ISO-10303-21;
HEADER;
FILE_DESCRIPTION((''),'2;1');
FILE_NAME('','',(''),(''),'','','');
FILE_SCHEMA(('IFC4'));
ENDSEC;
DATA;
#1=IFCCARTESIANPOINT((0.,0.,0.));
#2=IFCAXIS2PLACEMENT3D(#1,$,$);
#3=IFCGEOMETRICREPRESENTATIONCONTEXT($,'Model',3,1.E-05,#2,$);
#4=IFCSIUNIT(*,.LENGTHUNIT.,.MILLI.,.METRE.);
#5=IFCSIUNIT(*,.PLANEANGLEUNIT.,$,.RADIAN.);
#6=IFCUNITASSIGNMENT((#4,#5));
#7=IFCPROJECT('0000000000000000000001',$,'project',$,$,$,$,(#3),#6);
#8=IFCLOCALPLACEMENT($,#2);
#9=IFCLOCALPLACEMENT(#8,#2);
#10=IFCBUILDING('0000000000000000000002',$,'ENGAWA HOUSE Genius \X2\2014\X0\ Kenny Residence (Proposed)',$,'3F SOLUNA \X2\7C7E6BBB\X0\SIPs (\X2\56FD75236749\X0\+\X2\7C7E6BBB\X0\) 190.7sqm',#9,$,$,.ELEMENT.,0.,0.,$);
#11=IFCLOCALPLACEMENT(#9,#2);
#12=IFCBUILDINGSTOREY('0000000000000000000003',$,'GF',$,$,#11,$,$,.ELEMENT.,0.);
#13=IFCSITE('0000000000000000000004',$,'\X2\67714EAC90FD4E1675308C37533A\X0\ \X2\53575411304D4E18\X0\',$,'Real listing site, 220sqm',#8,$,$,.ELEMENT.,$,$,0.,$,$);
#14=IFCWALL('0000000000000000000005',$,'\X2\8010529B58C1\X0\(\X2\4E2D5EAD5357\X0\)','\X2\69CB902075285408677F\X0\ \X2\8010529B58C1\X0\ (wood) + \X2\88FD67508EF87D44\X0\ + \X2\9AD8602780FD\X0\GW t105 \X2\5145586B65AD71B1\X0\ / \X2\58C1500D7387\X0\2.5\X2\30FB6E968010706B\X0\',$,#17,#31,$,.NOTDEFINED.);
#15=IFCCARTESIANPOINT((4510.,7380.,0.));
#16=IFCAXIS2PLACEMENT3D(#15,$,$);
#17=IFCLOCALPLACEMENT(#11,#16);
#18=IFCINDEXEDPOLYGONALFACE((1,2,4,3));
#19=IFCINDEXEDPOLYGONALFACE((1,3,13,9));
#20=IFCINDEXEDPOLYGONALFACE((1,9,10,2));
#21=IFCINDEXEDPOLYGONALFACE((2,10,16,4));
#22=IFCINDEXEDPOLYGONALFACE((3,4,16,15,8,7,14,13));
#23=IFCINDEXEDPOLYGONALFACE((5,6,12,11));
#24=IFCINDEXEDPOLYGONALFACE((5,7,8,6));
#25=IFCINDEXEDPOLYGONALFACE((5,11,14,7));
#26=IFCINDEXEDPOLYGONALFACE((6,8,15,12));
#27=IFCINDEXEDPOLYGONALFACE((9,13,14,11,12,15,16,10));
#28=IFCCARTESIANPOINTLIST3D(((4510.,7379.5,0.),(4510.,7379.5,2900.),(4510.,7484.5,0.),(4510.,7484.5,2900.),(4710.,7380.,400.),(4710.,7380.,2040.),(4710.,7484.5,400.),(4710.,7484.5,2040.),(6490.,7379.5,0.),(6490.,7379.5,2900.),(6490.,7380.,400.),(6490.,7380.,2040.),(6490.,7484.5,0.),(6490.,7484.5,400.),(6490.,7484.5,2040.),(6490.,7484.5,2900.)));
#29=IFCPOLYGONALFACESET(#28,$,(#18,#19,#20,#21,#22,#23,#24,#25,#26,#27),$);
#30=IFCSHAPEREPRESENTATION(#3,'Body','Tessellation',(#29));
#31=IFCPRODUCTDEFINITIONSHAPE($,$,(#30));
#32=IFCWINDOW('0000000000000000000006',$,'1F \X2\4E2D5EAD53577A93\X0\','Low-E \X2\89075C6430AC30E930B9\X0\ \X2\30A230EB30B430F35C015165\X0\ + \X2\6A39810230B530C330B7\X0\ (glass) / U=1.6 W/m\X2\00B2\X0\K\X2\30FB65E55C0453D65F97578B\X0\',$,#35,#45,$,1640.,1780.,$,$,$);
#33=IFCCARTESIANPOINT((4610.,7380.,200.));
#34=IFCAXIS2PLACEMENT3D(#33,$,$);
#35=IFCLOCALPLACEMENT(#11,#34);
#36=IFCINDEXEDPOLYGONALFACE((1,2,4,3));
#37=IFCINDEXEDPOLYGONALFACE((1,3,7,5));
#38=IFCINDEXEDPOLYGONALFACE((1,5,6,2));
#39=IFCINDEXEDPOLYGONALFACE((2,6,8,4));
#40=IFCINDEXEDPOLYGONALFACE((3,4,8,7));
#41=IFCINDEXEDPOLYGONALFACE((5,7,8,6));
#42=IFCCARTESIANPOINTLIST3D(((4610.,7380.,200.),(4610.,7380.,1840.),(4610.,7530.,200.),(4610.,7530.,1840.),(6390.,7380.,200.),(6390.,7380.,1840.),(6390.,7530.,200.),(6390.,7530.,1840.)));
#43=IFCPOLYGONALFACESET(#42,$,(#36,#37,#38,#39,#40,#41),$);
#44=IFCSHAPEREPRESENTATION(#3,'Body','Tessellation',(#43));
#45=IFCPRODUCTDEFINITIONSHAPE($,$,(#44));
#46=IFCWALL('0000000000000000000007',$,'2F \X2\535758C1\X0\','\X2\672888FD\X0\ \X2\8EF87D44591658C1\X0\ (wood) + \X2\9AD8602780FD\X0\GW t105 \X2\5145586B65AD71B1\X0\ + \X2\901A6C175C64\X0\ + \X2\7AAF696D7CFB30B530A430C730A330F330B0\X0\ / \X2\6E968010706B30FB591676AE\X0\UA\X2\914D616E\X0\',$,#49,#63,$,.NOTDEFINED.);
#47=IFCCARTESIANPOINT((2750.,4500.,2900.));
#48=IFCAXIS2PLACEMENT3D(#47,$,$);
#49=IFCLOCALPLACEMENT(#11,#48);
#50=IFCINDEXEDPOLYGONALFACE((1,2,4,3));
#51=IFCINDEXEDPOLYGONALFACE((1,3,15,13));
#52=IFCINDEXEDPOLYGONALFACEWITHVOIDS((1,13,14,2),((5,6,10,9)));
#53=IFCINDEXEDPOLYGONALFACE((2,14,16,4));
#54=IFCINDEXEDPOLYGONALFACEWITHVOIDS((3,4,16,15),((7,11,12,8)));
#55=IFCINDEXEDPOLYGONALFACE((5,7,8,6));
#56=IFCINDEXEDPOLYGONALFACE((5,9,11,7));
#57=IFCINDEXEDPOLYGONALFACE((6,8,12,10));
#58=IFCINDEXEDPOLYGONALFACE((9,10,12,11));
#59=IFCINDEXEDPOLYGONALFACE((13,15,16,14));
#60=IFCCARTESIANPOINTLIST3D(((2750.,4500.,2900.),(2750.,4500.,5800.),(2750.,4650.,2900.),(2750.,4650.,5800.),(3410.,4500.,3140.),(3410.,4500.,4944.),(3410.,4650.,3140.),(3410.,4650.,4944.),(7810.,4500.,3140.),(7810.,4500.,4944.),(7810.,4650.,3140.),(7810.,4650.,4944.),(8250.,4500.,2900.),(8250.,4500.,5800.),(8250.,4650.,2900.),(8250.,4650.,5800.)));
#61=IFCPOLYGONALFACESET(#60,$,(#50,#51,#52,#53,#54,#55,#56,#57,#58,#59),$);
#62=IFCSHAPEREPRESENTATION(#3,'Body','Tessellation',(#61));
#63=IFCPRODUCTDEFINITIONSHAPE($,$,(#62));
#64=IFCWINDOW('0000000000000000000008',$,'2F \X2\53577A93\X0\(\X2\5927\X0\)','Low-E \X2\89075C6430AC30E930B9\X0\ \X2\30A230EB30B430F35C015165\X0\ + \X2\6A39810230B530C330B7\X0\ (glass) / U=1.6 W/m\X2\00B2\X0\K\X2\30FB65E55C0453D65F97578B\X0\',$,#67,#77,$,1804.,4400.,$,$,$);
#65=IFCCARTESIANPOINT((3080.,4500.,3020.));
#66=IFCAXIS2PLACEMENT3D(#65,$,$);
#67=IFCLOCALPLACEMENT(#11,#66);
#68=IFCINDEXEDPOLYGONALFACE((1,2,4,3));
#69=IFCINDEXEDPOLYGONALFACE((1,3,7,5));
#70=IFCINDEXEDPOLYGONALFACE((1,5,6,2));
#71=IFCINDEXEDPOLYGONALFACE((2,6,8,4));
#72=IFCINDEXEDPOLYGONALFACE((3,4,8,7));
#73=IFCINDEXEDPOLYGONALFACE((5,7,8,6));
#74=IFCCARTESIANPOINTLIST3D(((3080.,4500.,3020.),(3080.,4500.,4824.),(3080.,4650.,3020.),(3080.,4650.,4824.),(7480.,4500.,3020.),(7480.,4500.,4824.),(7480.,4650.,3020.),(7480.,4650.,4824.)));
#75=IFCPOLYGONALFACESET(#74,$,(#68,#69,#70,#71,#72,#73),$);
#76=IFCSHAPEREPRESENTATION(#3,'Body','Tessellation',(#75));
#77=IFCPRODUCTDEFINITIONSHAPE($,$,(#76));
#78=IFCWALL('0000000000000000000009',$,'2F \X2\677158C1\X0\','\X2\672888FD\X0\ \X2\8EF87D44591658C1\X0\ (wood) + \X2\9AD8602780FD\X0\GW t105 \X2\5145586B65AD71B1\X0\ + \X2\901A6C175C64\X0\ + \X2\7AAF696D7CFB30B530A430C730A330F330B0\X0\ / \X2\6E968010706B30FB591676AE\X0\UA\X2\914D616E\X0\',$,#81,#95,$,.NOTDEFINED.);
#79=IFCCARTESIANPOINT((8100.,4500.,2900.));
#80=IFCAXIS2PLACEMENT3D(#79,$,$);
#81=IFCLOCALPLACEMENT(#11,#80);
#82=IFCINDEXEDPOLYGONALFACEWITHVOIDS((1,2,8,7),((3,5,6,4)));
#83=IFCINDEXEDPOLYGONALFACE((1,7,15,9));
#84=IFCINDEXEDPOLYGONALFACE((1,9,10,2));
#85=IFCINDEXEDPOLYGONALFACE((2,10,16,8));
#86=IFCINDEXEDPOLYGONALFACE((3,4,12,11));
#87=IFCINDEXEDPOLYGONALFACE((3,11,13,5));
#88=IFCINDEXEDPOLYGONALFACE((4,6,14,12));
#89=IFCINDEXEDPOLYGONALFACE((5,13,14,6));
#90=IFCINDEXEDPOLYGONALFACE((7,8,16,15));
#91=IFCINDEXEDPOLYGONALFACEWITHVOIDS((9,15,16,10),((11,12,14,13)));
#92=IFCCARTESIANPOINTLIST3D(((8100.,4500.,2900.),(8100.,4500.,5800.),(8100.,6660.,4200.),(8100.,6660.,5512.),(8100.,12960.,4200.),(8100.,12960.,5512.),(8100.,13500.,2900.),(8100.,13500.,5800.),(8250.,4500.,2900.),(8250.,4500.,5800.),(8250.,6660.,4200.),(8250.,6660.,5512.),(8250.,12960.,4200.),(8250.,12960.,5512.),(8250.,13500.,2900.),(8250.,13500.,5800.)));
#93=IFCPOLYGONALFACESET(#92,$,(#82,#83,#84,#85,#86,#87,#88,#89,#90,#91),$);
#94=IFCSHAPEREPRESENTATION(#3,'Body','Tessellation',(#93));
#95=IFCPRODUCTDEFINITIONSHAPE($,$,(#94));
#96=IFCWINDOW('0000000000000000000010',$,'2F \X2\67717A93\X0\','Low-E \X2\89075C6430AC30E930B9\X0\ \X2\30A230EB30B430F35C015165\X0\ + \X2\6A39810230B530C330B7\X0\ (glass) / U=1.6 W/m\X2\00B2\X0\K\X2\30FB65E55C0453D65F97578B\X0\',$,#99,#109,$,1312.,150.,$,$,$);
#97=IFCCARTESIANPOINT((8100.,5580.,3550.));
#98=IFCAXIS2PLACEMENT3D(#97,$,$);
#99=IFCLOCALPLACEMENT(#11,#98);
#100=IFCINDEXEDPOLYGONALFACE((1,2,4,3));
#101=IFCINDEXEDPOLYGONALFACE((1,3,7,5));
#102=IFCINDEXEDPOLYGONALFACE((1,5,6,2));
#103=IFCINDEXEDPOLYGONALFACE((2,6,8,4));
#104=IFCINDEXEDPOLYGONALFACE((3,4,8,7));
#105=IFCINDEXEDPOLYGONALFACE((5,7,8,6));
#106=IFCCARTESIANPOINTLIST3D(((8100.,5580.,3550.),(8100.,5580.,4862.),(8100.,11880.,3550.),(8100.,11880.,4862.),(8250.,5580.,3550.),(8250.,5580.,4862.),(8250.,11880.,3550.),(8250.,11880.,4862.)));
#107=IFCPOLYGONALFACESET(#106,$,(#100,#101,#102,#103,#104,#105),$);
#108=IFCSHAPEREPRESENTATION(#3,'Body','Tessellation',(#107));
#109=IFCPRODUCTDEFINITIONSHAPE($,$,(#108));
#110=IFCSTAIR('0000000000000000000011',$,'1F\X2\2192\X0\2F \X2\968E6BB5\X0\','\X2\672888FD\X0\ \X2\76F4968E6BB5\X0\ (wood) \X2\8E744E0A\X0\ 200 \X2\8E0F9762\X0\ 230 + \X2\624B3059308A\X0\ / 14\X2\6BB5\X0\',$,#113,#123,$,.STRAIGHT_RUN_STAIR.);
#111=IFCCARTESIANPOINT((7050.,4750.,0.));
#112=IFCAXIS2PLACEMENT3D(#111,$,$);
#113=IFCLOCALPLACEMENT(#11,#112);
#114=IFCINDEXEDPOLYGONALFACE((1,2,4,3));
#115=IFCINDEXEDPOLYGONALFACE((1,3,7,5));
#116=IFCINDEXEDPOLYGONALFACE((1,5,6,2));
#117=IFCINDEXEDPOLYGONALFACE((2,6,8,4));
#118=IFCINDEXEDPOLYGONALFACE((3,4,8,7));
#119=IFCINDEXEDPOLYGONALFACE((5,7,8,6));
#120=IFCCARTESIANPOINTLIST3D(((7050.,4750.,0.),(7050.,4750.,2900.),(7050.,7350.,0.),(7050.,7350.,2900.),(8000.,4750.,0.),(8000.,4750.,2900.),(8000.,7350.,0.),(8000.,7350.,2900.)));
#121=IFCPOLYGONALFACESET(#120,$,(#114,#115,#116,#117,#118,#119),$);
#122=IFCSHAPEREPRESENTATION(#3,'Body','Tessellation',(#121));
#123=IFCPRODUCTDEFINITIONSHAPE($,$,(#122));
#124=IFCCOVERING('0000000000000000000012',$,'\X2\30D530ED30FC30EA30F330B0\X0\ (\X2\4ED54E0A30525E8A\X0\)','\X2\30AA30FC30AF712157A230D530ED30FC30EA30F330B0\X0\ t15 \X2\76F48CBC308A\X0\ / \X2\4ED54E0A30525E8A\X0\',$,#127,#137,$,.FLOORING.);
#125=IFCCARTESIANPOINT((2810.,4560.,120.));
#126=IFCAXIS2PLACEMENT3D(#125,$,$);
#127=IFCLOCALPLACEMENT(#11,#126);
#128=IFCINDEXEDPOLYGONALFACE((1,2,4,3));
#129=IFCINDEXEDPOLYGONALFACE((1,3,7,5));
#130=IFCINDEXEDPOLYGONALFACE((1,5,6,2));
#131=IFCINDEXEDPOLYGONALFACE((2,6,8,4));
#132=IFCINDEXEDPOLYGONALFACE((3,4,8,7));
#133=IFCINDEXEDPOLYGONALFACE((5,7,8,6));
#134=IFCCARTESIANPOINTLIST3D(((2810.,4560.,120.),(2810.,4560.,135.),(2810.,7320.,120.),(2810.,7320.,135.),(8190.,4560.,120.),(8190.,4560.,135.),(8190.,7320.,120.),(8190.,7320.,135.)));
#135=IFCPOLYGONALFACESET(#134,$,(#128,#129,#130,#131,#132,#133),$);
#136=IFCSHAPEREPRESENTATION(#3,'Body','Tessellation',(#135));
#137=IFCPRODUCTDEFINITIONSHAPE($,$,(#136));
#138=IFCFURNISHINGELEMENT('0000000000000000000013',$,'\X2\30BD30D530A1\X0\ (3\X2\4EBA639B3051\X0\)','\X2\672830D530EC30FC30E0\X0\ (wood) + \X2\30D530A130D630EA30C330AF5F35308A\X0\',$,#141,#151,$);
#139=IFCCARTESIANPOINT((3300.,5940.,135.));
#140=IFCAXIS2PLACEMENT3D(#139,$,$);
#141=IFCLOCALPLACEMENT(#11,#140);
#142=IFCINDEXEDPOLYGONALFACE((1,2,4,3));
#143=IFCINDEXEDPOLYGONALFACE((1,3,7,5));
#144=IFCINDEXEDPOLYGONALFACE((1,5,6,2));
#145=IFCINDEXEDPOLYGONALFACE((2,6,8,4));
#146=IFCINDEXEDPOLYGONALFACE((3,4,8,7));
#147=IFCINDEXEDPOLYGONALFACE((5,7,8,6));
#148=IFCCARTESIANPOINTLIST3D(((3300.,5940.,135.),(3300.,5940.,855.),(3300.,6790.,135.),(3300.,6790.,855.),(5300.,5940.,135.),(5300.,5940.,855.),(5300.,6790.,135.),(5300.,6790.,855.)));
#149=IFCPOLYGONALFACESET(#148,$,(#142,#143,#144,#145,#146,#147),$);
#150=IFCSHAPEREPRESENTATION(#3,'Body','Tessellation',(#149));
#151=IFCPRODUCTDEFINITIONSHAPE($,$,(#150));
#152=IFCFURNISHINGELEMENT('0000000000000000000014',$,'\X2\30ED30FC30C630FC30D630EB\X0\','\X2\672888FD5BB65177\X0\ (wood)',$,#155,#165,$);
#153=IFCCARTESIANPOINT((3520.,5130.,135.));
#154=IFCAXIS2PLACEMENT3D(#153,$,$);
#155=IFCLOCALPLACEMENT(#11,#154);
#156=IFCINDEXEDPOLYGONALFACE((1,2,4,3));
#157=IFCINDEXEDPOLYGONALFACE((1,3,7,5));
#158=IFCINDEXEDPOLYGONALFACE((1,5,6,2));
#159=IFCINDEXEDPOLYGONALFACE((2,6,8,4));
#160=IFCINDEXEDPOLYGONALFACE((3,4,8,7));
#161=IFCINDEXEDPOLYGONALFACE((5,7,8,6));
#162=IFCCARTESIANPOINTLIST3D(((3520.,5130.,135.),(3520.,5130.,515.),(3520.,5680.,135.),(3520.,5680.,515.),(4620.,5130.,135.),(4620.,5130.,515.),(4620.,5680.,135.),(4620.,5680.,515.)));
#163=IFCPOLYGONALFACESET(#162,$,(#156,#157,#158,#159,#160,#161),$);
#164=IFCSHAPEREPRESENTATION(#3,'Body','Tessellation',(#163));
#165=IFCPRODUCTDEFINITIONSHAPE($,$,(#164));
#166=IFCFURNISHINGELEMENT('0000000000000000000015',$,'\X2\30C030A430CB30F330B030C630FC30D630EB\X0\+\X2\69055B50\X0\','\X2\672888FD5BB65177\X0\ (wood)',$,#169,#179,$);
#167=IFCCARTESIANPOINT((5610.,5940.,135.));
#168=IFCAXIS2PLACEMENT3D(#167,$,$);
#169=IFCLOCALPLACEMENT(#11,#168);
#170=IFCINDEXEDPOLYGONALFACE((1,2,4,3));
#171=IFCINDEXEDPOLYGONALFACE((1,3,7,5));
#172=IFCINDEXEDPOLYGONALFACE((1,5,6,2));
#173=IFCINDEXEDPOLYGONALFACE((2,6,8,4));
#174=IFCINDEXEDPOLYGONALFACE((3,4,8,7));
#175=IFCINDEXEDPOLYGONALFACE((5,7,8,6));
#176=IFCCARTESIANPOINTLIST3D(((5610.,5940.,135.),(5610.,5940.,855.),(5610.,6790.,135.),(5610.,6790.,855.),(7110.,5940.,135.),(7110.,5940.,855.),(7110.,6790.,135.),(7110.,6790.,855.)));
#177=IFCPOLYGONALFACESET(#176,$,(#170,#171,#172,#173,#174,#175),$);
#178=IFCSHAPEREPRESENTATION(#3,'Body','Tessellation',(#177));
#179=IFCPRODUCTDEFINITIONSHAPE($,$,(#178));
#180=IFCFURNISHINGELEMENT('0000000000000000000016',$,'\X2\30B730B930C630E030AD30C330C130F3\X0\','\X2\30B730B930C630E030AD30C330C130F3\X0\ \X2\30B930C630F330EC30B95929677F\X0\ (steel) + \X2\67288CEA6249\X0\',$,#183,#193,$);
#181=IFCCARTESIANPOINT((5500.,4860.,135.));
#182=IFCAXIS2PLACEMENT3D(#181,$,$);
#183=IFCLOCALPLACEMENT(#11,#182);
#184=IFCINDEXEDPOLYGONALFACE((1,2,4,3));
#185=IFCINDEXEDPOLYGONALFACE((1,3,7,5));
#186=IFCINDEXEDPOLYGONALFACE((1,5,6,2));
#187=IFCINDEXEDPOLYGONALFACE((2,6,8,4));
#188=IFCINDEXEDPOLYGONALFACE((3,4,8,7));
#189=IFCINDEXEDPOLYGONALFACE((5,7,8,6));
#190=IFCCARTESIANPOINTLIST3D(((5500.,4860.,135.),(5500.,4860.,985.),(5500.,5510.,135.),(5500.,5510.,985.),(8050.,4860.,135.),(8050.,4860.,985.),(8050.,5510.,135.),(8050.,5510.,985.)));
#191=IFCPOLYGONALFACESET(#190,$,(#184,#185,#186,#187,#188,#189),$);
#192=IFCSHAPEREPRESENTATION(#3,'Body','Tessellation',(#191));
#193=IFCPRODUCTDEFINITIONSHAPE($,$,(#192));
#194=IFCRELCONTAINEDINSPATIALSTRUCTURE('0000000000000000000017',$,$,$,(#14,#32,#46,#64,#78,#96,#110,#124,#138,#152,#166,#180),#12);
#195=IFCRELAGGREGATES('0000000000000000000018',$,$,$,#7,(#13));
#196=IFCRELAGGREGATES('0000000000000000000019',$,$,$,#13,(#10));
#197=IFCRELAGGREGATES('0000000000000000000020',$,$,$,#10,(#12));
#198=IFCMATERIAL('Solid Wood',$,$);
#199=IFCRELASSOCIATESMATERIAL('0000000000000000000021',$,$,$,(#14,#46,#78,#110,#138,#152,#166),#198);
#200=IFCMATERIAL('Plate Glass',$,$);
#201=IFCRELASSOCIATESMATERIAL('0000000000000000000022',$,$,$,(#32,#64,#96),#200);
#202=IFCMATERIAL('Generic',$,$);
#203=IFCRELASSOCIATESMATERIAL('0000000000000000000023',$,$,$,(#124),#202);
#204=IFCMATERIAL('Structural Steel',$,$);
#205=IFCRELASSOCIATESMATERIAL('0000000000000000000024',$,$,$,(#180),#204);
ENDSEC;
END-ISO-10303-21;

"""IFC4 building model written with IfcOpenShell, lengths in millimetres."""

from ifc_helpers import new_model, si_unit, frame, frame_2d, origin, place, context, project, spatial, rectangle, extrude, material, element, fill, save


model = new_model("IFC4")

# Units and contexts
model_context = context("Model", 3, precision=1e-05, world=origin())
ifc_project = project(units=[si_unit("LENGTHUNIT", "METRE", prefix="MILLI"), si_unit("PLANEANGLEUNIT", "RADIAN")], contexts=[model_context])

# Site, building, storey
site_placement = place(None, origin())
site = spatial("IfcSite", under=ifc_project, at=site_placement, Name="東京都世田谷区 南向き丘", ObjectType="Real listing site, 220sqm", CompositionType="ELEMENT", RefElevation=0.0)
building_placement = place(site_placement, origin())
building = spatial("IfcBuilding", under=site, at=building_placement, Name="ENGAWA HOUSE Genius — Kenny Residence (Proposed)", ObjectType="3F SOLUNA 籾殻SIPs (国産杉+籾殻) 190.7sqm", CompositionType="ELEMENT", ElevationOfRefHeight=0.0, ElevationOfTerrain=0.0)
storey_placement = place(building_placement, origin())
storey = spatial("IfcBuildingStorey", under=building, at=storey_placement, Name="GF", CompositionType="ELEMENT", Elevation=0.0)

# Shared definitions
ifc_material_1 = material(Name="Solid Wood")
ifc_material_2 = material(Name="Generic")

# Shared definitions
ifc_material_3 = material(Name="Plate Glass")

# Wall, opening, window
wall_1_placement = place(storey_placement, frame((4510.0, 7380.0, 0.0)))
wall_1 = element("IfcWall", 1, at=wall_1_placement, inside=storey, material=ifc_material_1, Name="耐力壁(中庭南)", Description="構造用合板 耐力壁 (wood) + 製材軸組 + 高性能GW t105 充填断熱 / 壁倍率2.5・準耐火", PredefinedType="NOTDEFINED", context=model_context, shape_type="SweptSolid", body=[
    extrude(rectangle(XDim=1980.0, YDim=105.0, at=frame_2d((990.0, 52.0))), frame((4510.0, 7380.0, 0.0)), (0.0, 0.0, 1.0), 2900.0),
])
opening_1_placement = place(storey_placement, frame((4610.0, 7380.0, 200.0)))
opening_1 = element("IfcOpeningElement", 2, at=opening_1_placement, cuts=wall_1, PredefinedType="NOTDEFINED", context=model_context, shape_type="SweptSolid", body=[
    extrude(rectangle(XDim=1780.0, YDim=150.0, at=frame_2d((890.0, 75.0))), frame((4610.0, 7380.0, 200.0)), (0.0, 0.0, 1.0), 1640.0),
])
window_1_placement = place(storey_placement, frame((4610.0, 7380.0, 200.0)))
window_1 = element("IfcWindow", 3, at=window_1_placement, inside=storey, material=ifc_material_3, Name="1F 中庭南窓", Description="Low-E 複層ガラス アルゴン封入 + 樹脂サッシ (glass) / U=1.6 W/m²K・日射取得型", OverallHeight=1640.0, OverallWidth=1780.0, context=model_context, shape_type="SweptSolid", body=[
    extrude(rectangle(XDim=1780.0, YDim=150.0, at=frame_2d((890.0, 75.0))), frame((4610.0, 7380.0, 200.0)), (0.0, 0.0, 1.0), 1640.0),
])
fill(opening_1, window_1)

# Walls, openings, windows
wall_2_placement = place(storey_placement, frame((2750.0, 4500.0, 2900.0)))
wall_2 = element("IfcWall", 4, at=wall_2_placement, inside=storey, material=ifc_material_1, Name="2F 南壁", Description="木製 軸組外壁 (wood) + 高性能GW t105 充填断熱 + 通気層 + 窯業系サイディング / 準耐火・外皮UA配慮", PredefinedType="NOTDEFINED", context=model_context, shape_type="SweptSolid", body=[
    extrude(rectangle(XDim=5500.0, YDim=150.0, at=frame_2d((2750.0, 75.0))), frame((2750.0, 4500.0, 2900.0)), (0.0, 0.0, 1.0), 2900.0),
])
opening_2_placement = place(storey_placement, frame((3080.0, 4500.0, 3020.0)))
opening_2 = element("IfcOpeningElement", 5, at=opening_2_placement, cuts=wall_2, PredefinedType="NOTDEFINED", context=model_context, shape_type="SweptSolid", body=[
    extrude(rectangle(XDim=4400.0, YDim=150.0, at=frame_2d((2200.0, 75.0))), frame((3080.0, 4500.0, 3020.0)), (0.0, 0.0, 1.0), 1804.0),
])
window_2_placement = place(storey_placement, frame((3080.0, 4500.0, 3020.0)))
window_2 = element("IfcWindow", 6, at=window_2_placement, inside=storey, material=ifc_material_3, Name="2F 南窓(大)", Description="Low-E 複層ガラス アルゴン封入 + 樹脂サッシ (glass) / U=1.6 W/m²K・日射取得型", OverallHeight=1804.0, OverallWidth=4400.0, context=model_context, shape_type="SweptSolid", body=[
    extrude(rectangle(XDim=4400.0, YDim=150.0, at=frame_2d((2200.0, 75.0))), frame((3080.0, 4500.0, 3020.0)), (0.0, 0.0, 1.0), 1804.0),
])
fill(opening_2, window_2)
wall_3_placement = place(storey_placement, frame((8100.0, 4500.0, 2900.0)))
wall_3 = element("IfcWall", 7, at=wall_3_placement, inside=storey, material=ifc_material_1, Name="2F 東壁", Description="木製 軸組外壁 (wood) + 高性能GW t105 充填断熱 + 通気層 + 窯業系サイディング / 準耐火・外皮UA配慮", PredefinedType="NOTDEFINED", context=model_context, shape_type="SweptSolid", body=[
    extrude(rectangle(XDim=150.0, YDim=9000.0, at=frame_2d((75.0, 4500.0))), frame((8100.0, 4500.0, 2900.0)), (0.0, 0.0, 1.0), 2900.0),
])
opening_3_placement = place(storey_placement, frame((8100.0, 5580.0, 3550.0)))
opening_3 = element("IfcOpeningElement", 8, at=opening_3_placement, cuts=wall_3, PredefinedType="NOTDEFINED", context=model_context, shape_type="SweptSolid", body=[
    extrude(rectangle(XDim=150.0, YDim=6300.0, at=frame_2d((75.0, 3150.0))), frame((8100.0, 5580.0, 3550.0)), (0.0, 0.0, 1.0), 1312.0),
])
window_3_placement = place(storey_placement, frame((8100.0, 5580.0, 3550.0)))
window_3 = element("IfcWindow", 9, at=window_3_placement, inside=storey, material=ifc_material_3, Name="2F 東窓", Description="Low-E 複層ガラス アルゴン封入 + 樹脂サッシ (glass) / U=1.6 W/m²K・日射取得型", OverallHeight=1312.0, OverallWidth=150.0, context=model_context, shape_type="SweptSolid", body=[
    extrude(rectangle(XDim=150.0, YDim=6300.0, at=frame_2d((75.0, 3150.0))), frame((8100.0, 5580.0, 3550.0)), (0.0, 0.0, 1.0), 1312.0),
])
fill(opening_3, window_3)

# Stair
stair_placement = place(storey_placement, frame((7050.0, 4750.0, 0.0)))
element("IfcStair", 10, at=stair_placement, inside=storey, material=ifc_material_1, Name="1F→2F 階段", Description="木製 直階段 (wood) 蹴上 200 踏面 230 + 手すり / 14段", PredefinedType="STRAIGHT_RUN_STAIR", context=model_context, shape_type="SweptSolid", body=[
    extrude(rectangle(XDim=950.0, YDim=2600.0, at=frame_2d((475.0, 1300.0))), frame((7050.0, 4750.0, 0.0)), (0.0, 0.0, 1.0), 2900.0),
])

# Covering
covering_placement = place(storey_placement, frame((2810.0, 4560.0, 120.0)))
element("IfcCovering", 11, at=covering_placement, inside=storey, material=ifc_material_2, Name="フローリング (仕上げ床)", Description="オーク無垢フローリング t15 直貼り / 仕上げ床", PredefinedType="FLOORING", context=model_context, shape_type="SweptSolid", body=[
    extrude(rectangle(XDim=5380.0, YDim=2760.0, at=frame_2d((2690.0, 1380.0))), frame((2810.0, 4560.0, 120.0)), (0.0, 0.0, 1.0), 15.0),
])

# Furnishing elements
furnishing_1_placement = place(storey_placement, frame((3300.0, 5940.0, 135.0)))
element("IfcFurnishingElement", 12, at=furnishing_1_placement, inside=storey, material=ifc_material_1, Name="ソファ (3人掛け)", Description="木フレーム (wood) + ファブリック張り", context=model_context, shape_type="SweptSolid", body=[
    extrude(rectangle(XDim=2000.0, YDim=850.0, at=frame_2d((1000.0, 425.0))), frame((3300.0, 5940.0, 135.0)), (0.0, 0.0, 1.0), 720.0),
])
furnishing_2_placement = place(storey_placement, frame((3520.0, 5130.0, 135.0)))
element("IfcFurnishingElement", 13, at=furnishing_2_placement, inside=storey, material=ifc_material_1, Name="ローテーブル", Description="木製家具 (wood)", context=model_context, shape_type="SweptSolid", body=[
    extrude(rectangle(XDim=1100.0, YDim=550.0, at=frame_2d((550.0, 275.0))), frame((3520.0, 5130.0, 135.0)), (0.0, 0.0, 1.0), 380.0),
])
furnishing_3_placement = place(storey_placement, frame((5610.0, 5940.0, 135.0)))
element("IfcFurnishingElement", 14, at=furnishing_3_placement, inside=storey, material=ifc_material_1, Name="ダイニングテーブル+椅子", Description="木製家具 (wood)", context=model_context, shape_type="SweptSolid", body=[
    extrude(rectangle(XDim=1500.0, YDim=850.0, at=frame_2d((750.0, 425.0))), frame((5610.0, 5940.0, 135.0)), (0.0, 0.0, 1.0), 720.0),
])
ifc_material_4 = material(Name="Structural Steel")
furnishing_4_placement = place(storey_placement, frame((5500.0, 4860.0, 135.0)))
element("IfcFurnishingElement", 15, at=furnishing_4_placement, inside=storey, material=ifc_material_4, Name="システムキッチン", Description="システムキッチン ステンレス天板 (steel) + 木質扉", context=model_context, shape_type="SweptSolid", body=[
    extrude(rectangle(XDim=2550.0, YDim=650.0, at=frame_2d((1275.0, 325.0))), frame((5500.0, 4860.0, 135.0)), (0.0, 0.0, 1.0), 850.0),
])

save(model, "model.ifc")
